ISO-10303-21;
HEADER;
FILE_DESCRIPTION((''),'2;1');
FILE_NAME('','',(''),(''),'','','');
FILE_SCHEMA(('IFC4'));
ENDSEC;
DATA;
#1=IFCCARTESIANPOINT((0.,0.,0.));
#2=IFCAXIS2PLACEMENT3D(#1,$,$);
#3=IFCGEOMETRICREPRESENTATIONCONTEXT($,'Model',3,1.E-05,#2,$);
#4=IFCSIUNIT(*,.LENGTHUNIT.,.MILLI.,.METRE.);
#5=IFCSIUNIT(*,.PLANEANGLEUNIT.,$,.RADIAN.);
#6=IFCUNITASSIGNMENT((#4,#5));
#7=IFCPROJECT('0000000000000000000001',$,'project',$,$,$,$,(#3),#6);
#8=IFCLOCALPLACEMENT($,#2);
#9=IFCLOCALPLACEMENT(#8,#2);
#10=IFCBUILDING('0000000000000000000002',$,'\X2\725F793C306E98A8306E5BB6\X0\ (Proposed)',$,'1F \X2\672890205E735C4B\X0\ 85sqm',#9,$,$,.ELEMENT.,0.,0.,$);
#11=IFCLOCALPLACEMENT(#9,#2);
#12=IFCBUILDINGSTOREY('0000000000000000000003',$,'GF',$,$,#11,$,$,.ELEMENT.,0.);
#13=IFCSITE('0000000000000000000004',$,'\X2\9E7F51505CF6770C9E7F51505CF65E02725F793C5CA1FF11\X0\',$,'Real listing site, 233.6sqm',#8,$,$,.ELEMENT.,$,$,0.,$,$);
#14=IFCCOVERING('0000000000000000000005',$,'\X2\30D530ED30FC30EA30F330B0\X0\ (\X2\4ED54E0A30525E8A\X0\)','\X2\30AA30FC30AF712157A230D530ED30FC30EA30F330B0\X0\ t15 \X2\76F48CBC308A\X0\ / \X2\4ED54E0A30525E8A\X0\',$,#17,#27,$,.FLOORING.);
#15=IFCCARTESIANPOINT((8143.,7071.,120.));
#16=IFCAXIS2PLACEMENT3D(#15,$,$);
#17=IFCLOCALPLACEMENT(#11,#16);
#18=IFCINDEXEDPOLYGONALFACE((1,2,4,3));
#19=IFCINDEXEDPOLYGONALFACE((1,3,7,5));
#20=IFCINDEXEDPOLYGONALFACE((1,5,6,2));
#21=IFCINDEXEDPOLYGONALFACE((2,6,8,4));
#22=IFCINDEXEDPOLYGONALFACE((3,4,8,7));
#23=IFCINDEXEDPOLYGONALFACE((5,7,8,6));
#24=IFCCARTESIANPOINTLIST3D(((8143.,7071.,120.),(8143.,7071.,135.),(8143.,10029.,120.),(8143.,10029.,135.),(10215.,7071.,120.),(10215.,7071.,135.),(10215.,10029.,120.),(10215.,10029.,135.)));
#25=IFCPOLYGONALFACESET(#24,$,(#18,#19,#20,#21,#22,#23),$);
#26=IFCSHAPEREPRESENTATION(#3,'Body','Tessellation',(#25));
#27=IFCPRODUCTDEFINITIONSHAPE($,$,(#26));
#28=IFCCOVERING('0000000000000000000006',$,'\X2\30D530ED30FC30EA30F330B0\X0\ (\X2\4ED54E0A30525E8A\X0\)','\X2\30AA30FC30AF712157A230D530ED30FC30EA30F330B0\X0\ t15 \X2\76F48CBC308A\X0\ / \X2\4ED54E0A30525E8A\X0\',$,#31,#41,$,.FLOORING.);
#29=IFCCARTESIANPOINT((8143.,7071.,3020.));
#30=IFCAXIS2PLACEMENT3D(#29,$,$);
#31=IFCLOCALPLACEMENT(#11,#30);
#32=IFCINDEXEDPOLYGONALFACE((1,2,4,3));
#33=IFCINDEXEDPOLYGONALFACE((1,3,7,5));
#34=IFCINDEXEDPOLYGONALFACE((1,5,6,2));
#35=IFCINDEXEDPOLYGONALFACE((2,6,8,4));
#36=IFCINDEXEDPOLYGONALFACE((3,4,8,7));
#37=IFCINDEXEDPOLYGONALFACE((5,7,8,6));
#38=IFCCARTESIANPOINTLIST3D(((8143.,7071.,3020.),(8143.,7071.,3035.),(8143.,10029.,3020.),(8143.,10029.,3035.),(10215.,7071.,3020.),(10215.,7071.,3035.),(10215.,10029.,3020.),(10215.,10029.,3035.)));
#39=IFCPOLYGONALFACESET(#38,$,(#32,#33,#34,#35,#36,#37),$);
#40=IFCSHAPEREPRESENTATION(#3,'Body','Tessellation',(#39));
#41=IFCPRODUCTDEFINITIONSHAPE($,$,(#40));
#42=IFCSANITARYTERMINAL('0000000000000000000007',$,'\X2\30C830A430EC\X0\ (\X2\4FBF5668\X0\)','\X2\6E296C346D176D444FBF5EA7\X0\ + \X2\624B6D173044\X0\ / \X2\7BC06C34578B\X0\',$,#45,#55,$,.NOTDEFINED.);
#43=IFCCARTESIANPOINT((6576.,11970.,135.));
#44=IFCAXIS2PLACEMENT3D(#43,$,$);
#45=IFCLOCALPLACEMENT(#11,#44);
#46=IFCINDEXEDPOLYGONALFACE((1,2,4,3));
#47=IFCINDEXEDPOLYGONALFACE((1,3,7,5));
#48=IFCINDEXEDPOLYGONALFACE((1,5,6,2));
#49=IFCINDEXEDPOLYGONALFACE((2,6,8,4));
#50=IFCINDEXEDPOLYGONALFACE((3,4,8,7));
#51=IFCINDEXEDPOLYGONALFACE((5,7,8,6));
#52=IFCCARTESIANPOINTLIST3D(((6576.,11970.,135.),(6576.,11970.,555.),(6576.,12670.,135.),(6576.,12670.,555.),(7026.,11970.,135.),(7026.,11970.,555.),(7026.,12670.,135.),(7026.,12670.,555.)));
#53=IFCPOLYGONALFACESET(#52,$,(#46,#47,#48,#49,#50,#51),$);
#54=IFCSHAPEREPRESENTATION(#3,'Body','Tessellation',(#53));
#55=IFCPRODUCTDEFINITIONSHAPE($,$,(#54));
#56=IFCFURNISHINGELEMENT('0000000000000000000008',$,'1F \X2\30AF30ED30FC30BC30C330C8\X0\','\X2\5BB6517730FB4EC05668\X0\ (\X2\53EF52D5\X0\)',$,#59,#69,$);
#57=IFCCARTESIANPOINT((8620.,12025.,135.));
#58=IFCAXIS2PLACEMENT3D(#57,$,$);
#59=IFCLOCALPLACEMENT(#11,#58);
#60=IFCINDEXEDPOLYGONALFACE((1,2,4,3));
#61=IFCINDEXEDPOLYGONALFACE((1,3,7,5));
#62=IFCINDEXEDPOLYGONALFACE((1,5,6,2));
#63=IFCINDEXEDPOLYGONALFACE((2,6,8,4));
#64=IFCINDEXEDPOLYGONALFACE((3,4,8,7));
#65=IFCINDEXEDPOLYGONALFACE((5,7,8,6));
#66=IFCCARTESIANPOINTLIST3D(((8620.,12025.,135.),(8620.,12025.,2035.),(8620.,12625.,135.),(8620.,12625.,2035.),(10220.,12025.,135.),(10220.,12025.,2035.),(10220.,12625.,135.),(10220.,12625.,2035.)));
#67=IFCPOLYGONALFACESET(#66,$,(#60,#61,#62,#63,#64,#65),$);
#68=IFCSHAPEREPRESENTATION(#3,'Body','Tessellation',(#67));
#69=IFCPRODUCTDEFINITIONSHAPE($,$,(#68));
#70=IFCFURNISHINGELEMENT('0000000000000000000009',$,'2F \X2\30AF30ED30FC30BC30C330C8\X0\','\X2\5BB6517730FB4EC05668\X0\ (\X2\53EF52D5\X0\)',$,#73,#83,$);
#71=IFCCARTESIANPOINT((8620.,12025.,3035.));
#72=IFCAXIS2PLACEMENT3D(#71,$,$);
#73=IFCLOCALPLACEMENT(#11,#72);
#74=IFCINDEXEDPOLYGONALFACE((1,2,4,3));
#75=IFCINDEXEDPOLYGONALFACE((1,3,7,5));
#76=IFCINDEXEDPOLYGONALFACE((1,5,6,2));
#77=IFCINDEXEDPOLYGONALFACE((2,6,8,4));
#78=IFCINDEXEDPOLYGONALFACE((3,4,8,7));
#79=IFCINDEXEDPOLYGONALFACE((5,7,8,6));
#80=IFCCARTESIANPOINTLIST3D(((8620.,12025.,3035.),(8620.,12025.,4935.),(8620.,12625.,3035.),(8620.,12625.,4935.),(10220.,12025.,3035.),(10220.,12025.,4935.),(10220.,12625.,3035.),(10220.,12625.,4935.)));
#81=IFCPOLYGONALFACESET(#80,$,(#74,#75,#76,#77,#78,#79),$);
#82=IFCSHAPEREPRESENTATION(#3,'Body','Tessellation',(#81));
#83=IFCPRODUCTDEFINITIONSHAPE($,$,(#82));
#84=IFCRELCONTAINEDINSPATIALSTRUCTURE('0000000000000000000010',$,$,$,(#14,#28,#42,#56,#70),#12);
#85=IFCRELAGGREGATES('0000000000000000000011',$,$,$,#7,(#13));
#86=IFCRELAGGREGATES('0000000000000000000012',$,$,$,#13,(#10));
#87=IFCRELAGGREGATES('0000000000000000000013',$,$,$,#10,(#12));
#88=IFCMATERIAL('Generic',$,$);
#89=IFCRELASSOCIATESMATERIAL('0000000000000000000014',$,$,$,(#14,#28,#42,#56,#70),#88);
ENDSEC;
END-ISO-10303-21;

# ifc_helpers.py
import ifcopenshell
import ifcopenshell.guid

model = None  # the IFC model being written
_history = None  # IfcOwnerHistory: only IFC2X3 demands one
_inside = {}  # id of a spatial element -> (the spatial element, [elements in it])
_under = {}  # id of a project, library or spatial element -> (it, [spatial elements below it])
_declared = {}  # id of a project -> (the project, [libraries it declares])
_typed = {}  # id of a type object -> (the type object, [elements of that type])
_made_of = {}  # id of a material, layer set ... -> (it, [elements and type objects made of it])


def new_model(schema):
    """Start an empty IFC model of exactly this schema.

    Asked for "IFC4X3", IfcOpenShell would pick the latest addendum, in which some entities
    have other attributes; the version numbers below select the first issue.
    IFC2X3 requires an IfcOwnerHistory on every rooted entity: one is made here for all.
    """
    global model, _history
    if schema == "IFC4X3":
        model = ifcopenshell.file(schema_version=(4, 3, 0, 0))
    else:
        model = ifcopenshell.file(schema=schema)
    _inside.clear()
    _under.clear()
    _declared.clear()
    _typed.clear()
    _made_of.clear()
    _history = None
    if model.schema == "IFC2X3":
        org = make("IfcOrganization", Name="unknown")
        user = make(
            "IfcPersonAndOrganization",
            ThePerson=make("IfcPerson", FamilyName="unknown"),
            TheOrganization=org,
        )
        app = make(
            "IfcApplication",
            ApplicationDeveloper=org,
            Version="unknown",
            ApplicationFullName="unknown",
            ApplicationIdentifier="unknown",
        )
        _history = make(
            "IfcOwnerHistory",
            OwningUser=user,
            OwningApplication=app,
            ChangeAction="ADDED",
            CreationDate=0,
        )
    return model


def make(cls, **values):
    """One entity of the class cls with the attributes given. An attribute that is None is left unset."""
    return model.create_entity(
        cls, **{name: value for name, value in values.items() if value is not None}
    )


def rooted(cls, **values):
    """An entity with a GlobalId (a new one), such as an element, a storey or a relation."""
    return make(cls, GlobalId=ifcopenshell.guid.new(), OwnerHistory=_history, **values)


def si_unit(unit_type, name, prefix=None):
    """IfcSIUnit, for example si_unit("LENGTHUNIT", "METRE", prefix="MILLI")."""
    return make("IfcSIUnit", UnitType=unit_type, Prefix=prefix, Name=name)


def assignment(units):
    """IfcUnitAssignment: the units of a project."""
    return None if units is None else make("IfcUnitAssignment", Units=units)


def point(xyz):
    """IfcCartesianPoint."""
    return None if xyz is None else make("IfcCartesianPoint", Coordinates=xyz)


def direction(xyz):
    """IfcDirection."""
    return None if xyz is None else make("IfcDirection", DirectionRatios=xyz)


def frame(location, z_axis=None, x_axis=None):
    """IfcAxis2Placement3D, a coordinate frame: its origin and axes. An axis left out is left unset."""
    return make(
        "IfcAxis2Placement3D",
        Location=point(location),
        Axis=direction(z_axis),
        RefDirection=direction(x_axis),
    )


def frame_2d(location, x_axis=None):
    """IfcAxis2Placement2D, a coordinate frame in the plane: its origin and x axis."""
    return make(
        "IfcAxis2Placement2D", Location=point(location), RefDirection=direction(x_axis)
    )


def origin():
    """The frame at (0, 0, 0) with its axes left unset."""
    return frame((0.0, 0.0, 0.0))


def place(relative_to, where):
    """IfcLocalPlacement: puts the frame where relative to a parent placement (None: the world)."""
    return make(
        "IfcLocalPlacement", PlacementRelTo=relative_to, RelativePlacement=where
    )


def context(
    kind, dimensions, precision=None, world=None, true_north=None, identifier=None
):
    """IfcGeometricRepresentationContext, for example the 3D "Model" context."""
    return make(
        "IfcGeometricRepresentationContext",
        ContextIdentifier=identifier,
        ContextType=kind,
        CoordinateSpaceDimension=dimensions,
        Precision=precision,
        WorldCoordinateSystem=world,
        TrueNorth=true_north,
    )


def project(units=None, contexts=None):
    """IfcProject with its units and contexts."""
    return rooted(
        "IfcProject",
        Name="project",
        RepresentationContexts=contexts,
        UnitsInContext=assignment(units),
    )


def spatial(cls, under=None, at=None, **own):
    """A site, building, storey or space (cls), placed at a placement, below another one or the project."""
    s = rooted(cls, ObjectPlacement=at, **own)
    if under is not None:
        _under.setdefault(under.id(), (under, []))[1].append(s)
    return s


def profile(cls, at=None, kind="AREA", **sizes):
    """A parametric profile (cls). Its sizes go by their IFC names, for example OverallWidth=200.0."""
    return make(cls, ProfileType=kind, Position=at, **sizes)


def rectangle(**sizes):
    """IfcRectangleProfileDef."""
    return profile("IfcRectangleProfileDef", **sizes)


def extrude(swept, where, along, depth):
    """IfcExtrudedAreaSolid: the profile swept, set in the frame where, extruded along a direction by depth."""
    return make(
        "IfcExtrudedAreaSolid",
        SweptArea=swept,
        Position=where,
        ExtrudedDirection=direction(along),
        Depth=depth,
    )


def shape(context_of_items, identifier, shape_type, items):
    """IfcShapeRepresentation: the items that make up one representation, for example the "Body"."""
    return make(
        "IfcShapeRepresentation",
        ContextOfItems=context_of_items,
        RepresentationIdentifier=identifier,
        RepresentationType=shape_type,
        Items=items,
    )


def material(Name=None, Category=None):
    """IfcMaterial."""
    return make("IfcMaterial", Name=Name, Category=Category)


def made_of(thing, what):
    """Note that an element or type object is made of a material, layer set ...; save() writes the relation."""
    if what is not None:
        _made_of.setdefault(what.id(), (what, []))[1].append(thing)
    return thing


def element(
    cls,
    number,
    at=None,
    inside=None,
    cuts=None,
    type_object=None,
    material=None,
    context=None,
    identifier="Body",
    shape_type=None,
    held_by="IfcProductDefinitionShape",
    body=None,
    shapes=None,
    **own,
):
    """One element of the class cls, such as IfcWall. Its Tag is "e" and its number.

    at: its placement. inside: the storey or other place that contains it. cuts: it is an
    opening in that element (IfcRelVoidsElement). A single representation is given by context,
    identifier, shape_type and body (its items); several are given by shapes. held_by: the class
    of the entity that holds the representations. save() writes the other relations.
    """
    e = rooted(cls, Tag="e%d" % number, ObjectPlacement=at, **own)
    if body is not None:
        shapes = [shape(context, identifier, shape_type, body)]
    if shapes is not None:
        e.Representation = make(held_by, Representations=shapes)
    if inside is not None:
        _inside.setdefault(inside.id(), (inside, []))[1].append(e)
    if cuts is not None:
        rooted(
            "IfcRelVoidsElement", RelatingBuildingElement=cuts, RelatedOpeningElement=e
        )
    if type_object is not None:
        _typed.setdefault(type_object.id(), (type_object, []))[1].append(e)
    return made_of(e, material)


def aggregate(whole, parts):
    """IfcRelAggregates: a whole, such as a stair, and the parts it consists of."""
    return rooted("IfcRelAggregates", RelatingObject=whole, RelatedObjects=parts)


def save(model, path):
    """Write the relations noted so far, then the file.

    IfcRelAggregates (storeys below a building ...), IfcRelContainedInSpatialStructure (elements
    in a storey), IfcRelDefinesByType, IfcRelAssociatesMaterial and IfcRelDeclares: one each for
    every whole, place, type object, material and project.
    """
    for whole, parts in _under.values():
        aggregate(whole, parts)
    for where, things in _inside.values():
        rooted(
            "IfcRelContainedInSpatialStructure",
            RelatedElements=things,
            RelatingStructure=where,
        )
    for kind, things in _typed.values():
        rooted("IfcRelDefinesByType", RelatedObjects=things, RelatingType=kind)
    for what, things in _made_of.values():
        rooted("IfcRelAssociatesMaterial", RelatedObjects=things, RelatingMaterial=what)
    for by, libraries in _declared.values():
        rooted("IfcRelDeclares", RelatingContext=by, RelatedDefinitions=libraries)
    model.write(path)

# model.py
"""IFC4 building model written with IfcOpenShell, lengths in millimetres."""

from ifc_helpers import new_model, si_unit, frame, frame_2d, origin, place, context, project, spatial, rectangle, extrude, material, element, save


model = new_model("IFC4")

# Units and contexts
model_context = context("Model", 3, precision=1e-05, world=origin())
ifc_project = project(units=[si_unit("LENGTHUNIT", "METRE", prefix="MILLI"), si_unit("PLANEANGLEUNIT", "RADIAN")], contexts=[model_context])

# Site, building, storey
site_placement = place(None, origin())
site = spatial("IfcSite", under=ifc_project, at=site_placement, Name="鹿児島県鹿児島市牟礼岡１", ObjectType="Real listing site, 233.6sqm", CompositionType="ELEMENT", RefElevation=0.0)
building_placement = place(site_placement, origin())
building = spatial("IfcBuilding", under=site, at=building_placement, Name="牟礼の風の家 (Proposed)", ObjectType="1F 木造平屋 85sqm", CompositionType="ELEMENT", ElevationOfRefHeight=0.0, ElevationOfTerrain=0.0)
storey_placement = place(building_placement, origin())
storey = spatial("IfcBuildingStorey", under=building, at=storey_placement, Name="GF", CompositionType="ELEMENT", Elevation=0.0)

# Shared definitions
ifc_material_1 = material(Name="Generic")

# Coverings
covering_1_placement = place(storey_placement, frame((8143.0, 7071.0, 120.0)))
element("IfcCovering", 1, at=covering_1_placement, inside=storey, material=ifc_material_1, Name="フローリング (仕上げ床)", Description="オーク無垢フローリング t15 直貼り / 仕上げ床", PredefinedType="FLOORING", context=model_context, shape_type="SweptSolid", body=[
    extrude(rectangle(XDim=2072.0, YDim=2958.0, at=frame_2d((1036.0, 1479.0))), frame((8143.0, 7071.0, 120.0)), (0.0, 0.0, 1.0), 15.0),
])
covering_2_placement = place(storey_placement, frame((8143.0, 7071.0, 3020.0)))
element("IfcCovering", 2, at=covering_2_placement, inside=storey, material=ifc_material_1, Name="フローリング (仕上げ床)", Description="オーク無垢フローリング t15 直貼り / 仕上げ床", PredefinedType="FLOORING", context=model_context, shape_type="SweptSolid", body=[
    extrude(rectangle(XDim=2072.0, YDim=2958.0, at=frame_2d((1036.0, 1479.0))), frame((8143.0, 7071.0, 3020.0)), (0.0, 0.0, 1.0), 15.0),
])

# Sanitary terminal
sanitary_terminal_placement = place(storey_placement, frame((6576.0, 11970.0, 135.0)))
element("IfcSanitaryTerminal", 3, at=sanitary_terminal_placement, inside=storey, material=ifc_material_1, Name="トイレ (便器)", Description="温水洗浄便座 + 手洗い / 節水型", PredefinedType="NOTDEFINED", context=model_context, shape_type="SweptSolid", body=[
    extrude(rectangle(XDim=450.0, YDim=700.0, at=frame_2d((225.0, 350.0))), frame((6576.0, 11970.0, 135.0)), (0.0, 0.0, 1.0), 420.0),
])

# Furnishing elements
furnishing_1_placement = place(storey_placement, frame((8620.0, 12025.0, 135.0)))
element("IfcFurnishingElement", 4, at=furnishing_1_placement, inside=storey, material=ifc_material_1, Name="1F クローゼット", Description="家具・什器 (可動)", context=model_context, shape_type="SweptSolid", body=[
    extrude(rectangle(XDim=1600.0, YDim=600.0, at=frame_2d((800.0, 300.0))), frame((8620.0, 12025.0, 135.0)), (0.0, 0.0, 1.0), 1900.0),
])
furnishing_2_placement = place(storey_placement, frame((8620.0, 12025.0, 3035.0)))
element("IfcFurnishingElement", 5, at=furnishing_2_placement, inside=storey, material=ifc_material_1, Name="2F クローゼット", Description="家具・什器 (可動)", context=model_context, shape_type="SweptSolid", body=[
    extrude(rectangle(XDim=1600.0, YDim=600.0, at=frame_2d((800.0, 300.0))), frame((8620.0, 12025.0, 3035.0)), (0.0, 0.0, 1.0), 1900.0),
])

save(model, "model.ifc")
